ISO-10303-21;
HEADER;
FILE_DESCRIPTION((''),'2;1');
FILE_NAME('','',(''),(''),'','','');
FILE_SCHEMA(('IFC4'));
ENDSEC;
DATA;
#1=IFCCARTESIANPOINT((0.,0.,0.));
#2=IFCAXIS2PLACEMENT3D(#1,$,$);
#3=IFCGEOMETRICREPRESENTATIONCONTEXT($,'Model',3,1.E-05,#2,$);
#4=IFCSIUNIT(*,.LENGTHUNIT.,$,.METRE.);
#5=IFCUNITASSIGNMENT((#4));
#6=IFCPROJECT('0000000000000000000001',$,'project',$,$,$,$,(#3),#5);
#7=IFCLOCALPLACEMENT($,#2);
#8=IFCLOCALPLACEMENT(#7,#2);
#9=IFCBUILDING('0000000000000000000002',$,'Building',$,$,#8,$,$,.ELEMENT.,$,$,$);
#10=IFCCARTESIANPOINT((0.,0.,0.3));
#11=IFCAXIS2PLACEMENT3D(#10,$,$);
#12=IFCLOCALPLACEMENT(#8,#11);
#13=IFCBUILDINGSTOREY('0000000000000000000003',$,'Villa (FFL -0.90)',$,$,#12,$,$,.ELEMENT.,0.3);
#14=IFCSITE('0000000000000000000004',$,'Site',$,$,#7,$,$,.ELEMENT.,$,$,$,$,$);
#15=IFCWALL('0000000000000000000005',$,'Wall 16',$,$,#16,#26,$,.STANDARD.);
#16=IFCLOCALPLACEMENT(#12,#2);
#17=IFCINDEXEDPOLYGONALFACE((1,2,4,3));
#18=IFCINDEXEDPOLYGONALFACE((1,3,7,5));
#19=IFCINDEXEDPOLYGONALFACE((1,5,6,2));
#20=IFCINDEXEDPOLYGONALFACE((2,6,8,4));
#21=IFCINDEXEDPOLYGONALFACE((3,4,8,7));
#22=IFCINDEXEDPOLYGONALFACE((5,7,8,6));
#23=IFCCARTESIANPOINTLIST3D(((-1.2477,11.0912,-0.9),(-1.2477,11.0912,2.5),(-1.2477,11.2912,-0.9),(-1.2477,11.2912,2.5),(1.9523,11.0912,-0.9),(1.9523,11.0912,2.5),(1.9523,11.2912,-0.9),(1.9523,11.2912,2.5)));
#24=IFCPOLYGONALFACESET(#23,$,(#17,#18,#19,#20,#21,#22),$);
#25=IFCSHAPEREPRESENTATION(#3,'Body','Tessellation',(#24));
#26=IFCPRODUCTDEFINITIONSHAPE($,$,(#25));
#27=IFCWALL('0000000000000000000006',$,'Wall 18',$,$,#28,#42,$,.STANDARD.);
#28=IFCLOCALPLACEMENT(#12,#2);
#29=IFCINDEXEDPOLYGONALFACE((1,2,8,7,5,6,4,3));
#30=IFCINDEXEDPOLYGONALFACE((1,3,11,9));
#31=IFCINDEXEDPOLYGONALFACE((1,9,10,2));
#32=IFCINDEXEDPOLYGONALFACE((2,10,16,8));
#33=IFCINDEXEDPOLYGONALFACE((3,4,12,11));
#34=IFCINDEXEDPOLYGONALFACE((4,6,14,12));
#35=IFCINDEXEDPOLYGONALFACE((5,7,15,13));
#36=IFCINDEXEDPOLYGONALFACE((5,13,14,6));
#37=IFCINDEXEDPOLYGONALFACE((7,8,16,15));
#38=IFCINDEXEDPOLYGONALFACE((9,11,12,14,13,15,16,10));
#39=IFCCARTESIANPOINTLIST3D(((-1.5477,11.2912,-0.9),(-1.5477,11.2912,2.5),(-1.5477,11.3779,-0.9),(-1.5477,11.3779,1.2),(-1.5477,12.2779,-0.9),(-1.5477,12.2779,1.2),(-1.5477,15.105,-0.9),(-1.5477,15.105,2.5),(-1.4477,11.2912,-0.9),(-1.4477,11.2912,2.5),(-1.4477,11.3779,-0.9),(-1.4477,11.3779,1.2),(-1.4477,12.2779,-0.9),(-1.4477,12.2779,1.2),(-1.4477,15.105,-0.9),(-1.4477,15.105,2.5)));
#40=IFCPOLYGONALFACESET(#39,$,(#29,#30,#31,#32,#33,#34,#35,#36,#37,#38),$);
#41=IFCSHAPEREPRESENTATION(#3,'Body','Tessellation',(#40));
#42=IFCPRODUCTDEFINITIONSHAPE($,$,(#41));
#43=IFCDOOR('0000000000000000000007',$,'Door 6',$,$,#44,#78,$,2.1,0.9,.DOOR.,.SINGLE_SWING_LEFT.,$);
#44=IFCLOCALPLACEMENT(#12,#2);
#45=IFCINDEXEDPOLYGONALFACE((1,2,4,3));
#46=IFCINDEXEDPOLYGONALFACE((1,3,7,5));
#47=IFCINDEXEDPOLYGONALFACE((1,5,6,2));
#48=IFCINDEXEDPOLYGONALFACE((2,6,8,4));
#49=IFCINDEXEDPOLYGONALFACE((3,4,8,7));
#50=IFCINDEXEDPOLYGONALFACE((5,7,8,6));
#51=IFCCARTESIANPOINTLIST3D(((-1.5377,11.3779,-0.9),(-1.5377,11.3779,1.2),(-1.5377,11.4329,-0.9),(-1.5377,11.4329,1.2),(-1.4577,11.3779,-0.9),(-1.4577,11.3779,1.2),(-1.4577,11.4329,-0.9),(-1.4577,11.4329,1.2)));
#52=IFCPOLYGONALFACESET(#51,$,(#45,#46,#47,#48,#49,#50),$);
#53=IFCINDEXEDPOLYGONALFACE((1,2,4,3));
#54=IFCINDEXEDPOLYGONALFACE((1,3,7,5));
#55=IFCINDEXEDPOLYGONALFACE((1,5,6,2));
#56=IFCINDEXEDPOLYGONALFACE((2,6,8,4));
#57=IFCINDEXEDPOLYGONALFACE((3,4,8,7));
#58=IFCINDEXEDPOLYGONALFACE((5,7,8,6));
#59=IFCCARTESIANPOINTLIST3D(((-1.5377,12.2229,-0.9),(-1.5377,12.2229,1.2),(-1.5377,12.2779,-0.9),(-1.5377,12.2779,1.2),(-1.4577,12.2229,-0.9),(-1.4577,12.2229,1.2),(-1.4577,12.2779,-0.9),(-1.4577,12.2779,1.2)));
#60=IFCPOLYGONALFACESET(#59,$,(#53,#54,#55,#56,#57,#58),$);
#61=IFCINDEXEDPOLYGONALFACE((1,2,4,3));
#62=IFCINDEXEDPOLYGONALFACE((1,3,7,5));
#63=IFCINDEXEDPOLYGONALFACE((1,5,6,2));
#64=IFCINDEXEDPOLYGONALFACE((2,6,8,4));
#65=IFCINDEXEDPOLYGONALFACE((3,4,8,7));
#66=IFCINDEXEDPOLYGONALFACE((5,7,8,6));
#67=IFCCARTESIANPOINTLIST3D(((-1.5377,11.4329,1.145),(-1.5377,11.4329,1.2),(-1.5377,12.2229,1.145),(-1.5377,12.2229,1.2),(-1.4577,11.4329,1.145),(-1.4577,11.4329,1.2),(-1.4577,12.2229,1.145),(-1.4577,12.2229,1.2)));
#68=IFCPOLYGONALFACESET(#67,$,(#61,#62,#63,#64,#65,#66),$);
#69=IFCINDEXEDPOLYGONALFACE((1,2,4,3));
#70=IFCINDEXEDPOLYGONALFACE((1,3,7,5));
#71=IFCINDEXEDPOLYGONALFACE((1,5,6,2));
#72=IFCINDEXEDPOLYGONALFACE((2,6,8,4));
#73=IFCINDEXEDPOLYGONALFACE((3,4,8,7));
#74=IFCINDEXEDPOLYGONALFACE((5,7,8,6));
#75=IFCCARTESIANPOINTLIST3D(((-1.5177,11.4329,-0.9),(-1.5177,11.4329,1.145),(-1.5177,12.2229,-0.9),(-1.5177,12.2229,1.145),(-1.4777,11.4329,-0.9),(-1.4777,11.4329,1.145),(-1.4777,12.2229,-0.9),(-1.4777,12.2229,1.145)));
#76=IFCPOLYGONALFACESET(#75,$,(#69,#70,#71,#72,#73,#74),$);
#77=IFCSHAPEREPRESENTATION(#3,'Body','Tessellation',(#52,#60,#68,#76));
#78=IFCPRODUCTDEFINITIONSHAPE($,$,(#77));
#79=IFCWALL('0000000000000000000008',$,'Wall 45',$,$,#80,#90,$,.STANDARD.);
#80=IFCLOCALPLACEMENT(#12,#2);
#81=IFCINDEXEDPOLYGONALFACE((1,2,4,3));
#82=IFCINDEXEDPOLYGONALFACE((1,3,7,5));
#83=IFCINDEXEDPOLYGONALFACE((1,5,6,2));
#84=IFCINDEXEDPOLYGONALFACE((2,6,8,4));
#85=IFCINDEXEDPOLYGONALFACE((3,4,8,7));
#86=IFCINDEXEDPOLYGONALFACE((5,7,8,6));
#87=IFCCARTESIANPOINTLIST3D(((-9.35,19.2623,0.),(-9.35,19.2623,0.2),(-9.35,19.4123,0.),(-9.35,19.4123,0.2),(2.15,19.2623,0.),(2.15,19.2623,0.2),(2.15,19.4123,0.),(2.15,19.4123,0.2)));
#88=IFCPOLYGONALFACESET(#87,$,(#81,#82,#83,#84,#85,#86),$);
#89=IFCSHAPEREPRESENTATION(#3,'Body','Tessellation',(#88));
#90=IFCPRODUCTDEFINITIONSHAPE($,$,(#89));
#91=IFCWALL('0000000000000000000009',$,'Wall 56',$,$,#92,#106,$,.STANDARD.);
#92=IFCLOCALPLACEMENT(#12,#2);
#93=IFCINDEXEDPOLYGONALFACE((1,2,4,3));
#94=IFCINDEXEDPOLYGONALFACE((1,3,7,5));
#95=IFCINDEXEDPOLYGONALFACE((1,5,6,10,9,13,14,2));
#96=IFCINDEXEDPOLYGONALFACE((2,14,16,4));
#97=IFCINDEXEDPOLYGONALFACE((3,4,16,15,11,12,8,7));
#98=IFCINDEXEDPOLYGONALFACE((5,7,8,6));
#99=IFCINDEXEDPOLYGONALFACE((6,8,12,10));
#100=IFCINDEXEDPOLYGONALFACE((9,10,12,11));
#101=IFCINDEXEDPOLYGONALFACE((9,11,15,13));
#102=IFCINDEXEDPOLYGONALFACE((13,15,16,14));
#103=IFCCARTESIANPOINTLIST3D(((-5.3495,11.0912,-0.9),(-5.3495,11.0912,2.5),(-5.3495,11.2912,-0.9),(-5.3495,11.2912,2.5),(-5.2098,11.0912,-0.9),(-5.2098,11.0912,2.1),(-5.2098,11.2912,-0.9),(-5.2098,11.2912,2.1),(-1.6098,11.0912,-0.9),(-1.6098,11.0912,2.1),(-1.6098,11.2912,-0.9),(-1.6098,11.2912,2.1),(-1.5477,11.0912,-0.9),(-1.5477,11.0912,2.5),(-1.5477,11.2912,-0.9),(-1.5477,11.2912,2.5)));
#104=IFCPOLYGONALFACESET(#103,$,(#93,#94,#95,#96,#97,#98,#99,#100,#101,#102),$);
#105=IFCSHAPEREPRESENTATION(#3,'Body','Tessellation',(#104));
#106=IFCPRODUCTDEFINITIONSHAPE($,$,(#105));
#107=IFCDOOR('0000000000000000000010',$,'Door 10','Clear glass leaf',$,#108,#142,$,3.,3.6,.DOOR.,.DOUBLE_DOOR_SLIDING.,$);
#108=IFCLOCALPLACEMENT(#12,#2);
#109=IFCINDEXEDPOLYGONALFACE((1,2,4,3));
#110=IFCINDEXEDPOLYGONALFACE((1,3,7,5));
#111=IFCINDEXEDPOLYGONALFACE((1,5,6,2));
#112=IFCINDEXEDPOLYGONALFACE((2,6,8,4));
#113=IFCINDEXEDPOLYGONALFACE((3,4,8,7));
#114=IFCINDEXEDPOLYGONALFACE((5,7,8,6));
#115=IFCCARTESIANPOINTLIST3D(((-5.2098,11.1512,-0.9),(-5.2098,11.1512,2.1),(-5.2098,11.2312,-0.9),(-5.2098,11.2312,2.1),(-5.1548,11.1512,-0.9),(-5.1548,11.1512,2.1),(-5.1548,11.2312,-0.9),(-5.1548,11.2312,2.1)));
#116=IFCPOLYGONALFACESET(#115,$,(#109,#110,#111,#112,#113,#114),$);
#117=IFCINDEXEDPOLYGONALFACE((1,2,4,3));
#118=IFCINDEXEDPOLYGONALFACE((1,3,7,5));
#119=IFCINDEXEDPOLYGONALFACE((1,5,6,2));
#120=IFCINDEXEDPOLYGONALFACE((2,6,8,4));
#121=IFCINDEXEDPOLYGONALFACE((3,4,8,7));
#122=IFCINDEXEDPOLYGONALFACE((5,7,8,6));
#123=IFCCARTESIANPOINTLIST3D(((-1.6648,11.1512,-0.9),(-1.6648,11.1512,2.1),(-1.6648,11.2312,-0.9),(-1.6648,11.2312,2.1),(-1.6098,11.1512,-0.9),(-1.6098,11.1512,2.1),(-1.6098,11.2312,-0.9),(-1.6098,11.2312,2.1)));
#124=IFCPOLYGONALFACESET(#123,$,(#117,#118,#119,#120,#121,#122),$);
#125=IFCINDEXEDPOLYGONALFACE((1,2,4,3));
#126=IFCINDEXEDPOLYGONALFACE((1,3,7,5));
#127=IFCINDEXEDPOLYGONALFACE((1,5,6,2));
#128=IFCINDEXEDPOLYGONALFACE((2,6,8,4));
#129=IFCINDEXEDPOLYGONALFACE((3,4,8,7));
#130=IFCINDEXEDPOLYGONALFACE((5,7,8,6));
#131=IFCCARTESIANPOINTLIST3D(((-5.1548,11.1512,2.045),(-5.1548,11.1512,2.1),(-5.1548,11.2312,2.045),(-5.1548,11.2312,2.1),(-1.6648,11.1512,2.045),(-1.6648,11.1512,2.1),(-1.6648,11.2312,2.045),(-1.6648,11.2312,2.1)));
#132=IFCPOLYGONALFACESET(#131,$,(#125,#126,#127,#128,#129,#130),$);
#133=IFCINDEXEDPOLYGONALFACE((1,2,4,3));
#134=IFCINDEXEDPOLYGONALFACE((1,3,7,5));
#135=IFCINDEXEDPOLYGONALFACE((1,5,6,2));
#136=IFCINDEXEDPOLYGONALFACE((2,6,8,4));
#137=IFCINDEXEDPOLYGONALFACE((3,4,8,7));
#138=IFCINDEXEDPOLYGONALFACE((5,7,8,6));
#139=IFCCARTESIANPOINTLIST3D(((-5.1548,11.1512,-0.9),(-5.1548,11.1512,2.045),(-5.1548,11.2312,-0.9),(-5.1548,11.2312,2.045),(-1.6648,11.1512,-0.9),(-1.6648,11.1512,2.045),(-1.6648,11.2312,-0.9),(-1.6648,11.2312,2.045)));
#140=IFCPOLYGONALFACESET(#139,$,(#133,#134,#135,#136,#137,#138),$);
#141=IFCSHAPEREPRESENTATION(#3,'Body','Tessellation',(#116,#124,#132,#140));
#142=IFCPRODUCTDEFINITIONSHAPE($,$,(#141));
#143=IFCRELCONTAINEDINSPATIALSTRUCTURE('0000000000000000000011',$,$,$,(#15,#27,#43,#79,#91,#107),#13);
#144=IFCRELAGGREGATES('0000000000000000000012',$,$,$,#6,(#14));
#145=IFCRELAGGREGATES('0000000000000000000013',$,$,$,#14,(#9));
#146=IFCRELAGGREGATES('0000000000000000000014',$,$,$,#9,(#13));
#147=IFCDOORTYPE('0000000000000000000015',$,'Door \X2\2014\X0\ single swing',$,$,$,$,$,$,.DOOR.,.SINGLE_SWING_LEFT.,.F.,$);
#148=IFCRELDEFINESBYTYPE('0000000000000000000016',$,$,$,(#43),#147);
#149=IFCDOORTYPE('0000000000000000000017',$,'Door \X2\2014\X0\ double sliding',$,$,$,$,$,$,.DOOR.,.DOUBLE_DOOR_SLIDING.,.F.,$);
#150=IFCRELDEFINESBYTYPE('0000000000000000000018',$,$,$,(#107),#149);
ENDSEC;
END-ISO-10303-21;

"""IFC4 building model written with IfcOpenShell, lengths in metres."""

from ifc_helpers import new_model, si_unit, frame, frame_2d, origin, place, context, project, spatial, rectangle, extrude, type_object, element, fill, save


model = new_model("IFC4")

# Units and contexts
model_context = context("Model", 3, precision=1e-05, world=origin())
ifc_project = project(units=[si_unit("LENGTHUNIT", "METRE")], contexts=[model_context])

# Site, building, storey
site_placement = place(None, origin())
site = spatial("IfcSite", under=ifc_project, at=site_placement, Name="Site", CompositionType="ELEMENT")
building_placement = place(site_placement, origin())
building = spatial("IfcBuilding", under=site, at=building_placement, Name="Building", CompositionType="ELEMENT")
storey_placement = place(building_placement, frame((0.0, 0.0, 0.3)))
storey = spatial("IfcBuildingStorey", under=building, at=storey_placement, Name="Villa (FFL -0.90)", CompositionType="ELEMENT", Elevation=0.3)

# Wall
wall_1_placement = place(storey_placement, frame((-1.2477, 11.1912, -0.9), z_axis=(0.0, 0.0, 1.0), x_axis=(1.0, 0.0, 0.0)))
element("IfcWall", 1, at=wall_1_placement, inside=storey, Name="Wall 16", PredefinedType="STANDARD", context=model_context, shape_type="SweptSolid", body=[
    extrude(rectangle(XDim=3.2, YDim=0.2, at=frame_2d((1.6, 0.0))), origin(), (0.0, 0.0, 1.0), 3.4),
])

# Wall, opening, door
wall_2_placement = place(storey_placement, frame((-1.4977, 11.2912, -0.9), z_axis=(0.0, 0.0, 1.0), x_axis=(0.0, 1.0, 0.0)))
wall_2 = element("IfcWall", 2, at=wall_2_placement, inside=storey, Name="Wall 18", PredefinedType="STANDARD", context=model_context, shape_type="SweptSolid", body=[
    extrude(rectangle(XDim=3.8138, YDim=0.1, at=frame_2d((1.9069, 0.0))), origin(), (0.0, 0.0, 1.0), 3.4),
])
opening_1_placement = place(storey_placement, frame((-1.4977, 11.3779, -0.9), z_axis=(0.0, 0.0, 1.0), x_axis=(0.0, 1.0, 0.0)))
opening_1 = element("IfcOpeningElement", 3, at=opening_1_placement, cuts=wall_2, PredefinedType="OPENING", context=model_context, shape_type="SweptSolid", body=[
    extrude(rectangle(XDim=0.9, YDim=0.16, at=frame_2d((0.45, 0.0))), origin(), (0.0, 0.0, 1.0), 2.1),
])
door_type_1 = type_object("IfcDoorType", Name="Door — single swing", OperationType="SINGLE_SWING_LEFT", ParameterTakesPrecedence=False, PredefinedType="DOOR")
door_1_placement = place(storey_placement, frame((-1.4977, 11.3779, -0.9), z_axis=(0.0, 0.0, 1.0), x_axis=(0.0, 1.0, 0.0)))
door_1 = element("IfcDoor", 4, at=door_1_placement, inside=storey, type_object=door_type_1, Name="Door 6", OperationType="SINGLE_SWING_LEFT", OverallHeight=2.1, OverallWidth=0.9, PredefinedType="DOOR", context=model_context, shape_type="SweptSolid", body=[
    extrude(rectangle(XDim=0.055, YDim=0.08, at=frame_2d((0.0275, 0.0))), origin(), (0.0, 0.0, 1.0), 2.1),
    extrude(rectangle(XDim=0.055, YDim=0.08, at=frame_2d((0.8725, 0.0))), origin(), (0.0, 0.0, 1.0), 2.1),
    extrude(rectangle(XDim=0.79, YDim=0.08, at=frame_2d((0.45, 0.0))), frame((0.0, 0.0, 2.045)), (0.0, 0.0, 1.0), 0.055),
    extrude(rectangle(XDim=0.79, YDim=0.04, at=frame_2d((0.45, 0.0))), origin(), (0.0, 0.0, 1.0), 2.045),
])
fill(opening_1, door_1)

# Wall
wall_3_placement = place(storey_placement, frame((-9.35, 19.3373, 0.0), z_axis=(0.0, 0.0, 1.0), x_axis=(1.0, 0.0, 0.0)))
element("IfcWall", 5, at=wall_3_placement, inside=storey, Name="Wall 45", PredefinedType="STANDARD", context=model_context, shape_type="SweptSolid", body=[
    extrude(rectangle(XDim=11.5, YDim=0.15, at=frame_2d((5.75, 0.0))), origin(), (0.0, 0.0, 1.0), 0.2),
])

# Wall, opening, door
wall_4_placement = place(storey_placement, frame((-5.3495, 11.1912, -0.9), z_axis=(0.0, 0.0, 1.0), x_axis=(1.0, 0.0, 0.0)))
wall_4 = element("IfcWall", 6, at=wall_4_placement, inside=storey, Name="Wall 56", PredefinedType="STANDARD", context=model_context, shape_type="SweptSolid", body=[
    extrude(rectangle(XDim=3.8018, YDim=0.2, at=frame_2d((1.9009, 0.0))), origin(), (0.0, 0.0, 1.0), 3.4),
])
opening_2_placement = place(storey_placement, frame((-5.2098, 11.1912, -0.9), z_axis=(0.0, 0.0, 1.0), x_axis=(1.0, 0.0, 0.0)))
opening_2 = element("IfcOpeningElement", 7, at=opening_2_placement, cuts=wall_4, PredefinedType="OPENING", context=model_context, shape_type="SweptSolid", body=[
    extrude(rectangle(XDim=3.6, YDim=0.26, at=frame_2d((1.8, 0.0))), origin(), (0.0, 0.0, 1.0), 3.0),
])
door_type_2 = type_object("IfcDoorType", Name="Door — double sliding", OperationType="DOUBLE_DOOR_SLIDING", ParameterTakesPrecedence=False, PredefinedType="DOOR")
door_2_placement = place(storey_placement, frame((-5.2098, 11.1912, -0.9), z_axis=(0.0, 0.0, 1.0), x_axis=(1.0, 0.0, 0.0)))
door_2 = element("IfcDoor", 8, at=door_2_placement, inside=storey, type_object=door_type_2, Name="Door 10", Description="Clear glass leaf", OperationType="DOUBLE_DOOR_SLIDING", OverallHeight=3.0, OverallWidth=3.6, PredefinedType="DOOR", context=model_context, shape_type="SweptSolid", body=[
    extrude(rectangle(XDim=0.055, YDim=0.08, at=frame_2d((0.0275, 0.0))), origin(), (0.0, 0.0, 1.0), 3.0),
    extrude(rectangle(XDim=0.055, YDim=0.08, at=frame_2d((3.5725, 0.0))), origin(), (0.0, 0.0, 1.0), 3.0),
    extrude(rectangle(XDim=3.49, YDim=0.08, at=frame_2d((1.8, 0.0))), frame((0.0, 0.0, 2.945)), (0.0, 0.0, 1.0), 0.055),
    extrude(rectangle(XDim=3.49, YDim=0.08, at=frame_2d((1.8, 0.0))), origin(), (0.0, 0.0, 1.0), 2.945),
])
fill(opening_2, door_2)

save(model, "model.ifc")
